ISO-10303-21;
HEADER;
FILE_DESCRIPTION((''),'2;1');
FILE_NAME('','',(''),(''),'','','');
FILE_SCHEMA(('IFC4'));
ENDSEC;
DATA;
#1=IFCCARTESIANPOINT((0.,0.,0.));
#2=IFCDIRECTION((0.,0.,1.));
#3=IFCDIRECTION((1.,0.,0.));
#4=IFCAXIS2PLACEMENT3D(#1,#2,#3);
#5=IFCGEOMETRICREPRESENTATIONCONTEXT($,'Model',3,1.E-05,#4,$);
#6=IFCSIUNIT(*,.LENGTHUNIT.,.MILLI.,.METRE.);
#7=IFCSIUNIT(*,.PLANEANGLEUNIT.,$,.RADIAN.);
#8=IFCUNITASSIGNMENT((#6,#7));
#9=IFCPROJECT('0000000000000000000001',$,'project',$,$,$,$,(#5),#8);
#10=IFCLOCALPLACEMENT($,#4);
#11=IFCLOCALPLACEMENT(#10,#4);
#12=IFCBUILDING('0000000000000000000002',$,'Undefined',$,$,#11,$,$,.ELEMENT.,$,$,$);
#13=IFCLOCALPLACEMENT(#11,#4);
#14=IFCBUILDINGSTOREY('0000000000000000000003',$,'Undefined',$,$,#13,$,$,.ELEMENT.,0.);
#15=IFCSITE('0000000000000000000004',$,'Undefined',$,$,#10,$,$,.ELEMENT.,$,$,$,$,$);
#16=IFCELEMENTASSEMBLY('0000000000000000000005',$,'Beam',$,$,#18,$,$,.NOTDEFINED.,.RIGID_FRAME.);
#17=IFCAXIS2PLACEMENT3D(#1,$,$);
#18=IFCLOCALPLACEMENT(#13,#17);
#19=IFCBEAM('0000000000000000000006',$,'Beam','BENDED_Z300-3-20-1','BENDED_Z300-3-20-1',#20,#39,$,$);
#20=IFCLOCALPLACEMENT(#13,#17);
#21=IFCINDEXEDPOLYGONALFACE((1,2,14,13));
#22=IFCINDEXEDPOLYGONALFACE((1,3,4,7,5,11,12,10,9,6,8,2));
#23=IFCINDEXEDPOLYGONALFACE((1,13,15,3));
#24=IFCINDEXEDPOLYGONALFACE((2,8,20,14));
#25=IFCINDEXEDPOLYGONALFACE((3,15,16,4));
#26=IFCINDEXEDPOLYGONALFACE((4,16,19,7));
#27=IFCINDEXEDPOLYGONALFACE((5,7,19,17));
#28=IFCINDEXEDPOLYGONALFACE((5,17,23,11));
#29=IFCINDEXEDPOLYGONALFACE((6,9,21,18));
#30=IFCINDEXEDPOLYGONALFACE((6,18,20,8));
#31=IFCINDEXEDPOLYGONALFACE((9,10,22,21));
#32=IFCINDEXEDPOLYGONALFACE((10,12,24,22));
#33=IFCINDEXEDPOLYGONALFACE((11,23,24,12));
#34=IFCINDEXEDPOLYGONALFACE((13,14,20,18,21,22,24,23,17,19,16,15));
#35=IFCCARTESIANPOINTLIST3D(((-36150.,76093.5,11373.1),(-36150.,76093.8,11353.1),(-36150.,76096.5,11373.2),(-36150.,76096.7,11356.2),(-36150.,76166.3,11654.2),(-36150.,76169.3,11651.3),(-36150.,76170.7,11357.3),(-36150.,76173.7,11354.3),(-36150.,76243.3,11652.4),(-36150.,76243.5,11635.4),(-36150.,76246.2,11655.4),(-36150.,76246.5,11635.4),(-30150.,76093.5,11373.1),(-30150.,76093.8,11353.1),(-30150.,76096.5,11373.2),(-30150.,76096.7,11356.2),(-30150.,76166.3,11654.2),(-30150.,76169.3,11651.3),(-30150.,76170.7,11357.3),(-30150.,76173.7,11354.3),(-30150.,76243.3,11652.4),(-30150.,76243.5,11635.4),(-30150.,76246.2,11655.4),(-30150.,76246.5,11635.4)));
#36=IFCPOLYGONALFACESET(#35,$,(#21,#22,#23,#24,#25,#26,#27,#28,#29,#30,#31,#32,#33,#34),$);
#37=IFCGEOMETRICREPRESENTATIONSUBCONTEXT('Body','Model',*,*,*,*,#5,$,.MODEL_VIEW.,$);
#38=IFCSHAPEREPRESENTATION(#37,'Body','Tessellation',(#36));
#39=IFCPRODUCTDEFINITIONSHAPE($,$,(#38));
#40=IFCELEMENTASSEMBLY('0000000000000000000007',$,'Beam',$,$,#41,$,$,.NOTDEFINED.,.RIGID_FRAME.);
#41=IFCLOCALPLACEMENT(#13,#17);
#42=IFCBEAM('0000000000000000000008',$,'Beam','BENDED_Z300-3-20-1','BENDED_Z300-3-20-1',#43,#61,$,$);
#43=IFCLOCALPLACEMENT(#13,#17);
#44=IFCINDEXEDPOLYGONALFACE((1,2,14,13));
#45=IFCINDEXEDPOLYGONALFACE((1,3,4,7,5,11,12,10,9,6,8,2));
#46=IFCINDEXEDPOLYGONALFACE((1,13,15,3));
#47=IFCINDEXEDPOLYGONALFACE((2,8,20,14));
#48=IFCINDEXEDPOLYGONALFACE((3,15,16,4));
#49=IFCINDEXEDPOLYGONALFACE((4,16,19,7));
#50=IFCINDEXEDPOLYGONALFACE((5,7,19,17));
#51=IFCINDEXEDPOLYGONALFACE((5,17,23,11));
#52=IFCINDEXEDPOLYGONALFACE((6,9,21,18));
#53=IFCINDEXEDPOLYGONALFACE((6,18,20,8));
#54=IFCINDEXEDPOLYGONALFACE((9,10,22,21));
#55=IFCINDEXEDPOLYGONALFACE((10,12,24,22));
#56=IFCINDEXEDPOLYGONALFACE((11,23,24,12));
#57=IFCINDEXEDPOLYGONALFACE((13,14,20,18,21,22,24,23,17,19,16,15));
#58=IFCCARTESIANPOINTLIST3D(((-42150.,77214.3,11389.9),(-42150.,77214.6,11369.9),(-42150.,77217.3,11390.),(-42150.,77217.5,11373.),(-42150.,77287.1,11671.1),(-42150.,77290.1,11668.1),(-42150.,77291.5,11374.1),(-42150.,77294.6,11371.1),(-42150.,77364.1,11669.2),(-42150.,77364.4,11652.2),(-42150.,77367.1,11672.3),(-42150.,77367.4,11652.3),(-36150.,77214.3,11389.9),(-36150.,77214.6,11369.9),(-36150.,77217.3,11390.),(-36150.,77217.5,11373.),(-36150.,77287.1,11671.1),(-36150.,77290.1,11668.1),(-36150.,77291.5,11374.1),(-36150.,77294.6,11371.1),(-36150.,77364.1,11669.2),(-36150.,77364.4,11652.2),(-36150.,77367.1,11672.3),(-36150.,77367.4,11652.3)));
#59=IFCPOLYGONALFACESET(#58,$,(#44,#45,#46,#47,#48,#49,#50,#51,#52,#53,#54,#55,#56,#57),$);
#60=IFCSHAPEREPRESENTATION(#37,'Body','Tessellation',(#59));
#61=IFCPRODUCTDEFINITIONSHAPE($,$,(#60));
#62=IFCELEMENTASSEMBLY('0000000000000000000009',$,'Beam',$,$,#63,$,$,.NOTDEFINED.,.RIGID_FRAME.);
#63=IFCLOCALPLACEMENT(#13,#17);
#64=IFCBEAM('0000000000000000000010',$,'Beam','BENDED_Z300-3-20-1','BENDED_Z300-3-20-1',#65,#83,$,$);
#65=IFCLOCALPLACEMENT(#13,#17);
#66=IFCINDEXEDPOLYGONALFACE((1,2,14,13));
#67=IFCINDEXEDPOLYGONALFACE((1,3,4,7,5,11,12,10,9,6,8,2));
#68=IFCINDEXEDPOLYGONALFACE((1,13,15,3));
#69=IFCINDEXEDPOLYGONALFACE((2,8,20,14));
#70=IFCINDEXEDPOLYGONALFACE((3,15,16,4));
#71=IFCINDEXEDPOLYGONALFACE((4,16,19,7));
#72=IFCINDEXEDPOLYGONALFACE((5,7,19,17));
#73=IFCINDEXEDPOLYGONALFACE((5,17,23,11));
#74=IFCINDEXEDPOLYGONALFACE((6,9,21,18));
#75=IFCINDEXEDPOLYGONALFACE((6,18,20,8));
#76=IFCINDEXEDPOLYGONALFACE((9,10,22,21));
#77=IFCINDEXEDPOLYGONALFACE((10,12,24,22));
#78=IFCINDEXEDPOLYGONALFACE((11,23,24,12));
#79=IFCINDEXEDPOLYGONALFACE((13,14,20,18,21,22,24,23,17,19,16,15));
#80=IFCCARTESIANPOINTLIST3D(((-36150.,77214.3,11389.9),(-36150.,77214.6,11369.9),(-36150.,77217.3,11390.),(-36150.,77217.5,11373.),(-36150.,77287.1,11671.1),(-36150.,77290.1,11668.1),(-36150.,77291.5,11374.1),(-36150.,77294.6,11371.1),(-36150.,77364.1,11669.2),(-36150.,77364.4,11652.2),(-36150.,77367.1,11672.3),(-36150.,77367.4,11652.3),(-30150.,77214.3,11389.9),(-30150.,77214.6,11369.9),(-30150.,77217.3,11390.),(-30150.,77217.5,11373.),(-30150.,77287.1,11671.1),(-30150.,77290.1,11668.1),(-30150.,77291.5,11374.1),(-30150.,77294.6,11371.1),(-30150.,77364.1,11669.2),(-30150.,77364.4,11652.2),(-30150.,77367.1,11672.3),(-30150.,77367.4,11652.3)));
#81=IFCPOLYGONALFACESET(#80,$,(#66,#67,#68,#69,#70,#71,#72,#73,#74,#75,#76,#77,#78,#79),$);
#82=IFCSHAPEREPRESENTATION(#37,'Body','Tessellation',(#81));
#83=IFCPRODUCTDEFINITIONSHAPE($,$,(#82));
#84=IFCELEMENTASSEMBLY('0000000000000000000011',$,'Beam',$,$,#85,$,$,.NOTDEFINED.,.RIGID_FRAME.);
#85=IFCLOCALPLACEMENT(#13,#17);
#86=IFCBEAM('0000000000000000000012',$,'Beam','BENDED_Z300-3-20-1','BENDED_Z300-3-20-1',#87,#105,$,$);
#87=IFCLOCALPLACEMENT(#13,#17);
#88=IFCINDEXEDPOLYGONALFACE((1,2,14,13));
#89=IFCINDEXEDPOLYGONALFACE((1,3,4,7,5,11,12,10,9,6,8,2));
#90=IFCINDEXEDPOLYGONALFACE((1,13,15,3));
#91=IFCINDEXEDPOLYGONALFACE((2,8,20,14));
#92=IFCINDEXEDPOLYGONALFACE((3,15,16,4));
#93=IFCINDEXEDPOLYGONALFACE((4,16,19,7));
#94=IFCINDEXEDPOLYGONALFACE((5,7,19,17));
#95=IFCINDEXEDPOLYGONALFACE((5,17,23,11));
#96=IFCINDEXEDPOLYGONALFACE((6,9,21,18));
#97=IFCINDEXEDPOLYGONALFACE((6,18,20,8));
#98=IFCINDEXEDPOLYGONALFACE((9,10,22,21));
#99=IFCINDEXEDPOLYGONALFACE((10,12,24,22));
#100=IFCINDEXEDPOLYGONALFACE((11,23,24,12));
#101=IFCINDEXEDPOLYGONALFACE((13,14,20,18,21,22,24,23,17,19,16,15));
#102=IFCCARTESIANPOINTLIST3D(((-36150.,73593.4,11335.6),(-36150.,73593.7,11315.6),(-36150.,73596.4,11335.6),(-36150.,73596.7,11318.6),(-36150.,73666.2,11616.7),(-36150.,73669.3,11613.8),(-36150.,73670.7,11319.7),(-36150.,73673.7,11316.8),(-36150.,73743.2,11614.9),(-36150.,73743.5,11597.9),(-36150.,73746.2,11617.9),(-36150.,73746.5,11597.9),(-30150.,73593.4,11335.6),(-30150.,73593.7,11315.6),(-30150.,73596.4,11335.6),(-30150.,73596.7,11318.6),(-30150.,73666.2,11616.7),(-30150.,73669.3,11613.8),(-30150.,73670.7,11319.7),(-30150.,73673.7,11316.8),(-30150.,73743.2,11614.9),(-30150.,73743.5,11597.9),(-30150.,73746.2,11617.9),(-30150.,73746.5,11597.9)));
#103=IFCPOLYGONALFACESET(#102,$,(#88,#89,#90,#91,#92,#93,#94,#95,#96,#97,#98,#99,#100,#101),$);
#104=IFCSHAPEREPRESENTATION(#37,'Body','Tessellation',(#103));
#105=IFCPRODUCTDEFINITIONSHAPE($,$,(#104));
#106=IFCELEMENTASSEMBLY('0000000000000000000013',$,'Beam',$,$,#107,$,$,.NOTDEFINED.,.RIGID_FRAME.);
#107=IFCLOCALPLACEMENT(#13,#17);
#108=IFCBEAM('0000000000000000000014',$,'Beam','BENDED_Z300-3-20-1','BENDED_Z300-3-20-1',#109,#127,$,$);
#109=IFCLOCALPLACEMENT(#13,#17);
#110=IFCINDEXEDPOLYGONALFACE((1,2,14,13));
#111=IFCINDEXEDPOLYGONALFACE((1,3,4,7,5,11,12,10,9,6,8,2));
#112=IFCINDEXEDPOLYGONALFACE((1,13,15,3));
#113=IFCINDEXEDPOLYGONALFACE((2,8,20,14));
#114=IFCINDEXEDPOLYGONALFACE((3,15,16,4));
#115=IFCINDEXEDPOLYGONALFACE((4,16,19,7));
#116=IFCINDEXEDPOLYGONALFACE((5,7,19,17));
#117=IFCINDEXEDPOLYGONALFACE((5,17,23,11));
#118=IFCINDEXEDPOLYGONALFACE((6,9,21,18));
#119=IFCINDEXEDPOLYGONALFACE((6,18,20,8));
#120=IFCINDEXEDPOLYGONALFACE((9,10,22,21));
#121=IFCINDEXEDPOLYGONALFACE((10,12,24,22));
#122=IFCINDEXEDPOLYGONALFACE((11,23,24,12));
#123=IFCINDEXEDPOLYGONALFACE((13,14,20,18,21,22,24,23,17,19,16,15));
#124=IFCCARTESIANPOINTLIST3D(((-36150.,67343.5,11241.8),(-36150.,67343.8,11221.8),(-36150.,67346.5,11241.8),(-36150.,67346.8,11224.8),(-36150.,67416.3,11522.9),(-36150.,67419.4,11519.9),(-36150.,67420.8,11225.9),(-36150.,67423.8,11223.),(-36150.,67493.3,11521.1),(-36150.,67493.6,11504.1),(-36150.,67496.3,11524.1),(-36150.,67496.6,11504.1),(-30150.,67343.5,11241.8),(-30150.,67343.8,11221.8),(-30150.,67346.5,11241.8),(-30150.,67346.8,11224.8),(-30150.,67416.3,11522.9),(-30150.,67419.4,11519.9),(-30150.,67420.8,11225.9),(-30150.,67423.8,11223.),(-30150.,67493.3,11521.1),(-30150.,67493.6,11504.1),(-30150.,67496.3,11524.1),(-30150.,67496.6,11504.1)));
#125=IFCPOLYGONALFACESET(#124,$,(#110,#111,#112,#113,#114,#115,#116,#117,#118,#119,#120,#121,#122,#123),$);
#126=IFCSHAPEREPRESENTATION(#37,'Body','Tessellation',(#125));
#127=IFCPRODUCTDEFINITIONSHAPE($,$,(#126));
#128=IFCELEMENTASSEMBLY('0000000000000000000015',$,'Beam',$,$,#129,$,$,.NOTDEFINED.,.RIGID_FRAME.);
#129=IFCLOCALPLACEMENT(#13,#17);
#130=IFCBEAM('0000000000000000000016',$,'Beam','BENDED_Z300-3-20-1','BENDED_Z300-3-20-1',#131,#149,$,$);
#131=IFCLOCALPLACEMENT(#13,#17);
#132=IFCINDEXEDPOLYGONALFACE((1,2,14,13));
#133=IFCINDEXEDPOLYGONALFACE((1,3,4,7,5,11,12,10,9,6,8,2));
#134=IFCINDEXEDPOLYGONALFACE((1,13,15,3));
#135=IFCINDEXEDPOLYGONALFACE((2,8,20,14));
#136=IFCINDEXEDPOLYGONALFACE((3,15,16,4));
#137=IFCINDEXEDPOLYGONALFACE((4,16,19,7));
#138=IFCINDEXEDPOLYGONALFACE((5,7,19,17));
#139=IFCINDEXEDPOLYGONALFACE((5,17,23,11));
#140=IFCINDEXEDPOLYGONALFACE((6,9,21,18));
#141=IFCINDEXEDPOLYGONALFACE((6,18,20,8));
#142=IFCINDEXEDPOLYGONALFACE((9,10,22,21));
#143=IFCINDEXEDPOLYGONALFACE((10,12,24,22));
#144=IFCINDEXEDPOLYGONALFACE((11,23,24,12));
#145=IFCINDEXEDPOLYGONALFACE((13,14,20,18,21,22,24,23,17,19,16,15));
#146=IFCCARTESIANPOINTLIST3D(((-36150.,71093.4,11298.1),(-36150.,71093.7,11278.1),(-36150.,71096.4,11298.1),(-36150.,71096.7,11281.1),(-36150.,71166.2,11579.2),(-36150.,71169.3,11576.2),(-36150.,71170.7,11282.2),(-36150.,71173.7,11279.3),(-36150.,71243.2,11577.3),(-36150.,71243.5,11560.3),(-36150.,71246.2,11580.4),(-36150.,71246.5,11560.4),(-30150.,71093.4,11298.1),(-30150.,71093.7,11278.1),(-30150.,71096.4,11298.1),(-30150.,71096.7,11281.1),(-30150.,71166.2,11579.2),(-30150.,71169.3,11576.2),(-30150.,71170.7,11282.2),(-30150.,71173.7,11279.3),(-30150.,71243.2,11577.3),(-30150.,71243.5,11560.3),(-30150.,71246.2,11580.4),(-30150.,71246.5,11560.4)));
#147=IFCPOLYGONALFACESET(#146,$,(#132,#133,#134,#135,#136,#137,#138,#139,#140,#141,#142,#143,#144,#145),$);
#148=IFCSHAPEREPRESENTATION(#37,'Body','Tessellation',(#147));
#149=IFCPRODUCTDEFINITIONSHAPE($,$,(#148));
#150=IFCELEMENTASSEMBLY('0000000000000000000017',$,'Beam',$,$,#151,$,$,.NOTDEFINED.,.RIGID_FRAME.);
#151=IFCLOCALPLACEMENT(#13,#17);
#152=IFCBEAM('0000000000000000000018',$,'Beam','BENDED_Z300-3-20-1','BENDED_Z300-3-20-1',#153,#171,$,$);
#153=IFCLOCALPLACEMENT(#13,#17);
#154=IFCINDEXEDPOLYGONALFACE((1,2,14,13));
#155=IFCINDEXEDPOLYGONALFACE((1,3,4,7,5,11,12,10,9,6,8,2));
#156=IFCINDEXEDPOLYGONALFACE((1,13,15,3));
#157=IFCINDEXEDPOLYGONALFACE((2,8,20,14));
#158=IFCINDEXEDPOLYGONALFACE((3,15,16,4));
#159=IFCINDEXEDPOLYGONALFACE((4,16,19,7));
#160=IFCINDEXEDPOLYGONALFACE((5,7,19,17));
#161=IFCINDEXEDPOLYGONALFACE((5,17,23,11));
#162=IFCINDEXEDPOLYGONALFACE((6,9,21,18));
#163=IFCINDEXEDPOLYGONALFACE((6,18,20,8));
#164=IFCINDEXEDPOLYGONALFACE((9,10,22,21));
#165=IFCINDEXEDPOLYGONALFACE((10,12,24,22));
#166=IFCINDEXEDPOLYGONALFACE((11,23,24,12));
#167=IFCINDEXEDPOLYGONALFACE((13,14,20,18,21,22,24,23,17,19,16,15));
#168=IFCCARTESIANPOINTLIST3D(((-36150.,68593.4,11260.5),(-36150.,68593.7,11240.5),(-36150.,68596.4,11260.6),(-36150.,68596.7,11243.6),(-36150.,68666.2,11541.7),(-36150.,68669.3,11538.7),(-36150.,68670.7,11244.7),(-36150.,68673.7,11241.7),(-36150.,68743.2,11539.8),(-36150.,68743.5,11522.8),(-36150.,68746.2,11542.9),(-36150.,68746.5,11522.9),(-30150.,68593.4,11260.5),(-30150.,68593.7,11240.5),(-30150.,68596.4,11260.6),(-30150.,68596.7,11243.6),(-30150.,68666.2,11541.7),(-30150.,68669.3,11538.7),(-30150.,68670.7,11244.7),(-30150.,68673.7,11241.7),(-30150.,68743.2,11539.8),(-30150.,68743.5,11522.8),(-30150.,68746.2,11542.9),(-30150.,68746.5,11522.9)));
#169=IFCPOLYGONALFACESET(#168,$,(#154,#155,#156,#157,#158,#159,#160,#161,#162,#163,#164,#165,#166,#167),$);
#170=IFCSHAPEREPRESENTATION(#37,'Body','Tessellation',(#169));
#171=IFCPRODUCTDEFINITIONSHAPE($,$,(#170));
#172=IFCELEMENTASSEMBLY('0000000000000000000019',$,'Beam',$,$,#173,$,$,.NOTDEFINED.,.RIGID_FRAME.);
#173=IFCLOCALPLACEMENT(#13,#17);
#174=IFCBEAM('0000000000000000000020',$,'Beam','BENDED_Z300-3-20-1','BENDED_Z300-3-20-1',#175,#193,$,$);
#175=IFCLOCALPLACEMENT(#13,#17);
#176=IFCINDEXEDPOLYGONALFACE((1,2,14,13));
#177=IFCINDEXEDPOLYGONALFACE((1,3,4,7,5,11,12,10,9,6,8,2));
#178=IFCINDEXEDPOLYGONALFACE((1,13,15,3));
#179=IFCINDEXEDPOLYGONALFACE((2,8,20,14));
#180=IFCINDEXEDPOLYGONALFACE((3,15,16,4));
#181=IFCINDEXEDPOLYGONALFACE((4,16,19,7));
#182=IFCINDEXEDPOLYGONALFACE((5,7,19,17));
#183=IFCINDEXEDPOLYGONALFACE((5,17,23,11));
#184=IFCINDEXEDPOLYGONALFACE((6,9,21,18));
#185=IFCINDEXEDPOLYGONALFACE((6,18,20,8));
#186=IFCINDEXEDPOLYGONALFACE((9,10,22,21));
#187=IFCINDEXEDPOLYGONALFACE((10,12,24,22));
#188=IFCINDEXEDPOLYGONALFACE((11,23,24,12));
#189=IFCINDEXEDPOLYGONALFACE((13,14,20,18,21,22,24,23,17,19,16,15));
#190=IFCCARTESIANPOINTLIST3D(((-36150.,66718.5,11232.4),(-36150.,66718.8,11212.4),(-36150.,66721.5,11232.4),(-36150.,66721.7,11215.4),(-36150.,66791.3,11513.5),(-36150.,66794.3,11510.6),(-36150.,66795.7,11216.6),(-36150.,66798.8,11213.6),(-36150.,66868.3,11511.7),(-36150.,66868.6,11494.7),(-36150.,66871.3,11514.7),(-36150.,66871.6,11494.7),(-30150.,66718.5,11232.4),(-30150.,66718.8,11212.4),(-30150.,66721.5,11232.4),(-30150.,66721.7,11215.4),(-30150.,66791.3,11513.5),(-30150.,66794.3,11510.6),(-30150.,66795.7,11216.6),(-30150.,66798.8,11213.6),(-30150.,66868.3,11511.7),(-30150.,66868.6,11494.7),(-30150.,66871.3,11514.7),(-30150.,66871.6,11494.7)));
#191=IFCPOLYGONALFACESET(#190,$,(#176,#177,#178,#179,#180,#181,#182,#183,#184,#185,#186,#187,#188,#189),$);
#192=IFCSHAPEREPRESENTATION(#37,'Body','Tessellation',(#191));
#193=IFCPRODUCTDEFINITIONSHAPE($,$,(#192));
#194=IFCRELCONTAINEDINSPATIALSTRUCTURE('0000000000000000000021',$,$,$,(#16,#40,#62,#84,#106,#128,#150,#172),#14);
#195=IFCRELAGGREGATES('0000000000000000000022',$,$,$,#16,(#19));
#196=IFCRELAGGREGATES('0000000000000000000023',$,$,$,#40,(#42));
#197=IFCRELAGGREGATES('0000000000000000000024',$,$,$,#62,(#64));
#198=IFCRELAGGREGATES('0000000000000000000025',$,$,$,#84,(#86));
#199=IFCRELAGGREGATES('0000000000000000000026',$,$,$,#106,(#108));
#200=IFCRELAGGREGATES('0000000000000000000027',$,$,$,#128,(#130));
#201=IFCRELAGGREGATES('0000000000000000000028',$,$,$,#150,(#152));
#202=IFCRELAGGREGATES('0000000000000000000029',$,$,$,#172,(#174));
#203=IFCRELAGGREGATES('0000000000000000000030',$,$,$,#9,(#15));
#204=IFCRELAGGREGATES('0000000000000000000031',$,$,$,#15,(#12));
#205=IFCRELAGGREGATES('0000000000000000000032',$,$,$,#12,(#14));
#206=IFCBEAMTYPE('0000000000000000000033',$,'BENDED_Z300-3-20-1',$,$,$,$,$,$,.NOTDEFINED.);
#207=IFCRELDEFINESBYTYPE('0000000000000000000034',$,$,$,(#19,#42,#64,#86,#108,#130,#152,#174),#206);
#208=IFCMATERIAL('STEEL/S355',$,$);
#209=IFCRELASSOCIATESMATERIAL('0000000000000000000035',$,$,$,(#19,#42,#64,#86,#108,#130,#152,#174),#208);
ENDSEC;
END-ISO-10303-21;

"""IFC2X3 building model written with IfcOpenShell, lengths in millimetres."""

from ifc_helpers import new_model, si_unit, frame, origin_with_axes, place, context, subcontext, project, spatial, polyline, outline, extrude, material, type_object, element, aggregate, save


model = new_model("IFC2X3")

# Units and contexts
model_context = context("Model", 3, precision=1e-05, world=origin_with_axes())
body_context = subcontext(model_context, "Body", "Model", "MODEL_VIEW")
ifc_project = project(units=[si_unit("LENGTHUNIT", "METRE", prefix="MILLI"), si_unit("PLANEANGLEUNIT", "RADIAN")], contexts=[model_context])

# Site, building, storey
site_placement = place(None, origin_with_axes())
site = spatial("IfcSite", under=ifc_project, at=site_placement, Name="Undefined", CompositionType="ELEMENT")
building_placement = place(site_placement, origin_with_axes())
building = spatial("IfcBuilding", under=site, at=building_placement, Name="Undefined", CompositionType="ELEMENT")
storey_placement = place(building_placement, origin_with_axes())
storey = spatial("IfcBuildingStorey", under=building, at=storey_placement, Name="Undefined", CompositionType="ELEMENT", Elevation=0.0)

# Shared definitions
ifc_material = material(Name="STEEL/S355")

# Element assemblies, beams
beam_type_1 = type_object("IfcBeamType", Name="BENDED_Z300-3-20-1", PredefinedType="NOTDEFINED")
assembly_1_placement = place(storey_placement, origin_with_axes())
assembly_1 = element("IfcElementAssembly", 1, at=assembly_1_placement, inside=storey, Name="Beam", AssemblyPlace="NOTDEFINED", PredefinedType="RIGID_FRAME")
beam_1_placement = place(assembly_1_placement, frame((-30150.0, 76170.0, 11504.3), z_axis=(0.0, -0.014963, 0.999888), x_axis=(-1.0, 0.0, 0.0)))
beam_1 = element("IfcBeam", 2, at=beam_1_placement, type_object=beam_type_1, material=ifc_material, Name="Beam", Description="BENDED_Z300-3-20-1", ObjectType="BENDED_Z300-3-20-1", context=body_context, shape_type="SweptSolid", body=[
    extrude(outline(polyline([(1.5, -150.0), (-78.5, -150.0), (-78.5, -130.0), (-75.5, -130.0), (-75.5, -147.0), (-1.5, -147.0), (-1.5, 150.0), (78.5, 150.0), (78.5, 130.0), (75.5, 130.0), (75.5, 147.0), (1.5, 147.0), (1.5, -150.0)])), frame((6000.0, 0.0, 0.0), z_axis=(-1.0, 0.0, 0.0), x_axis=(0.0, -1.0, 0.0)), (0.0, 0.0, 1.0), 6000.0),
])
aggregate(assembly_1, [beam_1])
assembly_2_placement = place(storey_placement, origin_with_axes())
assembly_2 = element("IfcElementAssembly", 3, at=assembly_2_placement, inside=storey, Name="Beam", AssemblyPlace="NOTDEFINED", PredefinedType="RIGID_FRAME")
beam_2_placement = place(assembly_2_placement, frame((-36150.0, 77290.8, 11521.1), z_axis=(0.0, -0.014963, 0.999888), x_axis=(-1.0, 0.0, 0.0)))
beam_2 = element("IfcBeam", 4, at=beam_2_placement, type_object=beam_type_1, material=ifc_material, Name="Beam", Description="BENDED_Z300-3-20-1", ObjectType="BENDED_Z300-3-20-1", context=body_context, shape_type="SweptSolid", body=[
    extrude(outline(polyline([(1.5, -150.0), (-78.5, -150.0), (-78.5, -130.0), (-75.5, -130.0), (-75.5, -147.0), (-1.5, -147.0), (-1.5, 150.0), (78.5, 150.0), (78.5, 130.0), (75.5, 130.0), (75.5, 147.0), (1.5, 147.0), (1.5, -150.0)])), frame((6000.0, 0.0, 0.0), z_axis=(-1.0, 0.0, 0.0), x_axis=(0.0, -1.0, 0.0)), (0.0, 0.0, 1.0), 6000.0),
])
aggregate(assembly_2, [beam_2])
assembly_3_placement = place(storey_placement, origin_with_axes())
assembly_3 = element("IfcElementAssembly", 5, at=assembly_3_placement, inside=storey, Name="Beam", AssemblyPlace="NOTDEFINED", PredefinedType="RIGID_FRAME")
beam_3_placement = place(assembly_3_placement, frame((-30150.0, 77290.8, 11521.1), z_axis=(0.0, -0.014963, 0.999888), x_axis=(-1.0, 0.0, 0.0)))
beam_3 = element("IfcBeam", 6, at=beam_3_placement, type_object=beam_type_1, material=ifc_material, Name="Beam", Description="BENDED_Z300-3-20-1", ObjectType="BENDED_Z300-3-20-1", context=body_context, shape_type="SweptSolid", body=[
    extrude(outline(polyline([(1.5, -150.0), (-78.5, -150.0), (-78.5, -130.0), (-75.5, -130.0), (-75.5, -147.0), (-1.5, -147.0), (-1.5, 150.0), (78.5, 150.0), (78.5, 130.0), (75.5, 130.0), (75.5, 147.0), (1.5, 147.0), (1.5, -150.0)])), frame((6000.0, 0.0, 0.0), z_axis=(-1.0, 0.0, 0.0), x_axis=(0.0, -1.0, 0.0)), (0.0, 0.0, 1.0), 6000.0),
])
aggregate(assembly_3, [beam_3])
assembly_4_placement = place(storey_placement, origin_with_axes())
assembly_4 = element("IfcElementAssembly", 7, at=assembly_4_placement, inside=storey, Name="Beam", AssemblyPlace="NOTDEFINED", PredefinedType="RIGID_FRAME")
beam_4_placement = place(assembly_4_placement, frame((-30150.0, 73670.0, 11466.8), z_axis=(0.0, -0.014963, 0.999888), x_axis=(-1.0, 0.0, 0.0)))
beam_4 = element("IfcBeam", 8, at=beam_4_placement, type_object=beam_type_1, material=ifc_material, Name="Beam", Description="BENDED_Z300-3-20-1", ObjectType="BENDED_Z300-3-20-1", context=body_context, shape_type="SweptSolid", body=[
    extrude(outline(polyline([(1.5, -150.0), (-78.5, -150.0), (-78.5, -130.0), (-75.5, -130.0), (-75.5, -147.0), (-1.5, -147.0), (-1.5, 150.0), (78.5, 150.0), (78.5, 130.0), (75.5, 130.0), (75.5, 147.0), (1.5, 147.0), (1.5, -150.0)])), frame((6000.0, 0.0, 0.0), z_axis=(-1.0, 0.0, 0.0), x_axis=(0.0, -1.0, 0.0)), (0.0, 0.0, 1.0), 6000.0),
])
aggregate(assembly_4, [beam_4])
assembly_5_placement = place(storey_placement, origin_with_axes())
assembly_5 = element("IfcElementAssembly", 9, at=assembly_5_placement, inside=storey, Name="Beam", AssemblyPlace="NOTDEFINED", PredefinedType="RIGID_FRAME")
beam_5_placement = place(assembly_5_placement, frame((-30150.0, 67420.1, 11372.9), z_axis=(0.0, -0.014963, 0.999888), x_axis=(-1.0, 0.0, 0.0)))
beam_5 = element("IfcBeam", 10, at=beam_5_placement, type_object=beam_type_1, material=ifc_material, Name="Beam", Description="BENDED_Z300-3-20-1", ObjectType="BENDED_Z300-3-20-1", context=body_context, shape_type="SweptSolid", body=[
    extrude(outline(polyline([(1.5, -150.0), (-78.5, -150.0), (-78.5, -130.0), (-75.5, -130.0), (-75.5, -147.0), (-1.5, -147.0), (-1.5, 150.0), (78.5, 150.0), (78.5, 130.0), (75.5, 130.0), (75.5, 147.0), (1.5, 147.0), (1.5, -150.0)])), frame((6000.0, 0.0, 0.0), z_axis=(-1.0, 0.0, 0.0), x_axis=(0.0, -1.0, 0.0)), (0.0, 0.0, 1.0), 6000.0),
])
aggregate(assembly_5, [beam_5])
assembly_6_placement = place(storey_placement, origin_with_axes())
assembly_6 = element("IfcElementAssembly", 11, at=assembly_6_placement, inside=storey, Name="Beam", AssemblyPlace="NOTDEFINED", PredefinedType="RIGID_FRAME")
beam_6_placement = place(assembly_6_placement, frame((-30150.0, 71170.0, 11429.2), z_axis=(0.0, -0.014963, 0.999888), x_axis=(-1.0, 0.0, 0.0)))
beam_6 = element("IfcBeam", 12, at=beam_6_placement, type_object=beam_type_1, material=ifc_material, Name="Beam", Description="BENDED_Z300-3-20-1", ObjectType="BENDED_Z300-3-20-1", context=body_context, shape_type="SweptSolid", body=[
    extrude(outline(polyline([(1.5, -150.0), (-78.5, -150.0), (-78.5, -130.0), (-75.5, -130.0), (-75.5, -147.0), (-1.5, -147.0), (-1.5, 150.0), (78.5, 150.0), (78.5, 130.0), (75.5, 130.0), (75.5, 147.0), (1.5, 147.0), (1.5, -150.0)])), frame((6000.0, 0.0, 0.0), z_axis=(-1.0, 0.0, 0.0), x_axis=(0.0, -1.0, 0.0)), (0.0, 0.0, 1.0), 6000.0),
])
aggregate(assembly_6, [beam_6])
assembly_7_placement = place(storey_placement, origin_with_axes())
assembly_7 = element("IfcElementAssembly", 13, at=assembly_7_placement, inside=storey, Name="Beam", AssemblyPlace="NOTDEFINED", PredefinedType="RIGID_FRAME")
beam_7_placement = place(assembly_7_placement, frame((-30150.0, 68670.0, 11391.7), z_axis=(0.0, -0.014963, 0.999888), x_axis=(-1.0, 0.0, 0.0)))
beam_7 = element("IfcBeam", 14, at=beam_7_placement, type_object=beam_type_1, material=ifc_material, Name="Beam", Description="BENDED_Z300-3-20-1", ObjectType="BENDED_Z300-3-20-1", context=body_context, shape_type="SweptSolid", body=[
    extrude(outline(polyline([(1.5, -150.0), (-78.5, -150.0), (-78.5, -130.0), (-75.5, -130.0), (-75.5, -147.0), (-1.5, -147.0), (-1.5, 150.0), (78.5, 150.0), (78.5, 130.0), (75.5, 130.0), (75.5, 147.0), (1.5, 147.0), (1.5, -150.0)])), frame((6000.0, 0.0, 0.0), z_axis=(-1.0, 0.0, 0.0), x_axis=(0.0, -1.0, 0.0)), (0.0, 0.0, 1.0), 6000.0),
])
aggregate(assembly_7, [beam_7])
assembly_8_placement = place(storey_placement, origin_with_axes())
assembly_8 = element("IfcElementAssembly", 15, at=assembly_8_placement, inside=storey, Name="Beam", AssemblyPlace="NOTDEFINED", PredefinedType="RIGID_FRAME")
beam_8_placement = place(assembly_8_placement, frame((-30150.0, 66795.0, 11363.6), z_axis=(0.0, -0.014963, 0.999888), x_axis=(-1.0, 0.0, 0.0)))
beam_8 = element("IfcBeam", 16, at=beam_8_placement, type_object=beam_type_1, material=ifc_material, Name="Beam", Description="BENDED_Z300-3-20-1", ObjectType="BENDED_Z300-3-20-1", context=body_context, shape_type="SweptSolid", body=[
    extrude(outline(polyline([(1.5, -150.0), (-78.5, -150.0), (-78.5, -130.0), (-75.5, -130.0), (-75.5, -147.0), (-1.5, -147.0), (-1.5, 150.0), (78.5, 150.0), (78.5, 130.0), (75.5, 130.0), (75.5, 147.0), (1.5, 147.0), (1.5, -150.0)])), frame((6000.0, 0.0, 0.0), z_axis=(-1.0, 0.0, 0.0), x_axis=(0.0, -1.0, 0.0)), (0.0, 0.0, 1.0), 6000.0),
])
aggregate(assembly_8, [beam_8])

save(model, "model.ifc")
